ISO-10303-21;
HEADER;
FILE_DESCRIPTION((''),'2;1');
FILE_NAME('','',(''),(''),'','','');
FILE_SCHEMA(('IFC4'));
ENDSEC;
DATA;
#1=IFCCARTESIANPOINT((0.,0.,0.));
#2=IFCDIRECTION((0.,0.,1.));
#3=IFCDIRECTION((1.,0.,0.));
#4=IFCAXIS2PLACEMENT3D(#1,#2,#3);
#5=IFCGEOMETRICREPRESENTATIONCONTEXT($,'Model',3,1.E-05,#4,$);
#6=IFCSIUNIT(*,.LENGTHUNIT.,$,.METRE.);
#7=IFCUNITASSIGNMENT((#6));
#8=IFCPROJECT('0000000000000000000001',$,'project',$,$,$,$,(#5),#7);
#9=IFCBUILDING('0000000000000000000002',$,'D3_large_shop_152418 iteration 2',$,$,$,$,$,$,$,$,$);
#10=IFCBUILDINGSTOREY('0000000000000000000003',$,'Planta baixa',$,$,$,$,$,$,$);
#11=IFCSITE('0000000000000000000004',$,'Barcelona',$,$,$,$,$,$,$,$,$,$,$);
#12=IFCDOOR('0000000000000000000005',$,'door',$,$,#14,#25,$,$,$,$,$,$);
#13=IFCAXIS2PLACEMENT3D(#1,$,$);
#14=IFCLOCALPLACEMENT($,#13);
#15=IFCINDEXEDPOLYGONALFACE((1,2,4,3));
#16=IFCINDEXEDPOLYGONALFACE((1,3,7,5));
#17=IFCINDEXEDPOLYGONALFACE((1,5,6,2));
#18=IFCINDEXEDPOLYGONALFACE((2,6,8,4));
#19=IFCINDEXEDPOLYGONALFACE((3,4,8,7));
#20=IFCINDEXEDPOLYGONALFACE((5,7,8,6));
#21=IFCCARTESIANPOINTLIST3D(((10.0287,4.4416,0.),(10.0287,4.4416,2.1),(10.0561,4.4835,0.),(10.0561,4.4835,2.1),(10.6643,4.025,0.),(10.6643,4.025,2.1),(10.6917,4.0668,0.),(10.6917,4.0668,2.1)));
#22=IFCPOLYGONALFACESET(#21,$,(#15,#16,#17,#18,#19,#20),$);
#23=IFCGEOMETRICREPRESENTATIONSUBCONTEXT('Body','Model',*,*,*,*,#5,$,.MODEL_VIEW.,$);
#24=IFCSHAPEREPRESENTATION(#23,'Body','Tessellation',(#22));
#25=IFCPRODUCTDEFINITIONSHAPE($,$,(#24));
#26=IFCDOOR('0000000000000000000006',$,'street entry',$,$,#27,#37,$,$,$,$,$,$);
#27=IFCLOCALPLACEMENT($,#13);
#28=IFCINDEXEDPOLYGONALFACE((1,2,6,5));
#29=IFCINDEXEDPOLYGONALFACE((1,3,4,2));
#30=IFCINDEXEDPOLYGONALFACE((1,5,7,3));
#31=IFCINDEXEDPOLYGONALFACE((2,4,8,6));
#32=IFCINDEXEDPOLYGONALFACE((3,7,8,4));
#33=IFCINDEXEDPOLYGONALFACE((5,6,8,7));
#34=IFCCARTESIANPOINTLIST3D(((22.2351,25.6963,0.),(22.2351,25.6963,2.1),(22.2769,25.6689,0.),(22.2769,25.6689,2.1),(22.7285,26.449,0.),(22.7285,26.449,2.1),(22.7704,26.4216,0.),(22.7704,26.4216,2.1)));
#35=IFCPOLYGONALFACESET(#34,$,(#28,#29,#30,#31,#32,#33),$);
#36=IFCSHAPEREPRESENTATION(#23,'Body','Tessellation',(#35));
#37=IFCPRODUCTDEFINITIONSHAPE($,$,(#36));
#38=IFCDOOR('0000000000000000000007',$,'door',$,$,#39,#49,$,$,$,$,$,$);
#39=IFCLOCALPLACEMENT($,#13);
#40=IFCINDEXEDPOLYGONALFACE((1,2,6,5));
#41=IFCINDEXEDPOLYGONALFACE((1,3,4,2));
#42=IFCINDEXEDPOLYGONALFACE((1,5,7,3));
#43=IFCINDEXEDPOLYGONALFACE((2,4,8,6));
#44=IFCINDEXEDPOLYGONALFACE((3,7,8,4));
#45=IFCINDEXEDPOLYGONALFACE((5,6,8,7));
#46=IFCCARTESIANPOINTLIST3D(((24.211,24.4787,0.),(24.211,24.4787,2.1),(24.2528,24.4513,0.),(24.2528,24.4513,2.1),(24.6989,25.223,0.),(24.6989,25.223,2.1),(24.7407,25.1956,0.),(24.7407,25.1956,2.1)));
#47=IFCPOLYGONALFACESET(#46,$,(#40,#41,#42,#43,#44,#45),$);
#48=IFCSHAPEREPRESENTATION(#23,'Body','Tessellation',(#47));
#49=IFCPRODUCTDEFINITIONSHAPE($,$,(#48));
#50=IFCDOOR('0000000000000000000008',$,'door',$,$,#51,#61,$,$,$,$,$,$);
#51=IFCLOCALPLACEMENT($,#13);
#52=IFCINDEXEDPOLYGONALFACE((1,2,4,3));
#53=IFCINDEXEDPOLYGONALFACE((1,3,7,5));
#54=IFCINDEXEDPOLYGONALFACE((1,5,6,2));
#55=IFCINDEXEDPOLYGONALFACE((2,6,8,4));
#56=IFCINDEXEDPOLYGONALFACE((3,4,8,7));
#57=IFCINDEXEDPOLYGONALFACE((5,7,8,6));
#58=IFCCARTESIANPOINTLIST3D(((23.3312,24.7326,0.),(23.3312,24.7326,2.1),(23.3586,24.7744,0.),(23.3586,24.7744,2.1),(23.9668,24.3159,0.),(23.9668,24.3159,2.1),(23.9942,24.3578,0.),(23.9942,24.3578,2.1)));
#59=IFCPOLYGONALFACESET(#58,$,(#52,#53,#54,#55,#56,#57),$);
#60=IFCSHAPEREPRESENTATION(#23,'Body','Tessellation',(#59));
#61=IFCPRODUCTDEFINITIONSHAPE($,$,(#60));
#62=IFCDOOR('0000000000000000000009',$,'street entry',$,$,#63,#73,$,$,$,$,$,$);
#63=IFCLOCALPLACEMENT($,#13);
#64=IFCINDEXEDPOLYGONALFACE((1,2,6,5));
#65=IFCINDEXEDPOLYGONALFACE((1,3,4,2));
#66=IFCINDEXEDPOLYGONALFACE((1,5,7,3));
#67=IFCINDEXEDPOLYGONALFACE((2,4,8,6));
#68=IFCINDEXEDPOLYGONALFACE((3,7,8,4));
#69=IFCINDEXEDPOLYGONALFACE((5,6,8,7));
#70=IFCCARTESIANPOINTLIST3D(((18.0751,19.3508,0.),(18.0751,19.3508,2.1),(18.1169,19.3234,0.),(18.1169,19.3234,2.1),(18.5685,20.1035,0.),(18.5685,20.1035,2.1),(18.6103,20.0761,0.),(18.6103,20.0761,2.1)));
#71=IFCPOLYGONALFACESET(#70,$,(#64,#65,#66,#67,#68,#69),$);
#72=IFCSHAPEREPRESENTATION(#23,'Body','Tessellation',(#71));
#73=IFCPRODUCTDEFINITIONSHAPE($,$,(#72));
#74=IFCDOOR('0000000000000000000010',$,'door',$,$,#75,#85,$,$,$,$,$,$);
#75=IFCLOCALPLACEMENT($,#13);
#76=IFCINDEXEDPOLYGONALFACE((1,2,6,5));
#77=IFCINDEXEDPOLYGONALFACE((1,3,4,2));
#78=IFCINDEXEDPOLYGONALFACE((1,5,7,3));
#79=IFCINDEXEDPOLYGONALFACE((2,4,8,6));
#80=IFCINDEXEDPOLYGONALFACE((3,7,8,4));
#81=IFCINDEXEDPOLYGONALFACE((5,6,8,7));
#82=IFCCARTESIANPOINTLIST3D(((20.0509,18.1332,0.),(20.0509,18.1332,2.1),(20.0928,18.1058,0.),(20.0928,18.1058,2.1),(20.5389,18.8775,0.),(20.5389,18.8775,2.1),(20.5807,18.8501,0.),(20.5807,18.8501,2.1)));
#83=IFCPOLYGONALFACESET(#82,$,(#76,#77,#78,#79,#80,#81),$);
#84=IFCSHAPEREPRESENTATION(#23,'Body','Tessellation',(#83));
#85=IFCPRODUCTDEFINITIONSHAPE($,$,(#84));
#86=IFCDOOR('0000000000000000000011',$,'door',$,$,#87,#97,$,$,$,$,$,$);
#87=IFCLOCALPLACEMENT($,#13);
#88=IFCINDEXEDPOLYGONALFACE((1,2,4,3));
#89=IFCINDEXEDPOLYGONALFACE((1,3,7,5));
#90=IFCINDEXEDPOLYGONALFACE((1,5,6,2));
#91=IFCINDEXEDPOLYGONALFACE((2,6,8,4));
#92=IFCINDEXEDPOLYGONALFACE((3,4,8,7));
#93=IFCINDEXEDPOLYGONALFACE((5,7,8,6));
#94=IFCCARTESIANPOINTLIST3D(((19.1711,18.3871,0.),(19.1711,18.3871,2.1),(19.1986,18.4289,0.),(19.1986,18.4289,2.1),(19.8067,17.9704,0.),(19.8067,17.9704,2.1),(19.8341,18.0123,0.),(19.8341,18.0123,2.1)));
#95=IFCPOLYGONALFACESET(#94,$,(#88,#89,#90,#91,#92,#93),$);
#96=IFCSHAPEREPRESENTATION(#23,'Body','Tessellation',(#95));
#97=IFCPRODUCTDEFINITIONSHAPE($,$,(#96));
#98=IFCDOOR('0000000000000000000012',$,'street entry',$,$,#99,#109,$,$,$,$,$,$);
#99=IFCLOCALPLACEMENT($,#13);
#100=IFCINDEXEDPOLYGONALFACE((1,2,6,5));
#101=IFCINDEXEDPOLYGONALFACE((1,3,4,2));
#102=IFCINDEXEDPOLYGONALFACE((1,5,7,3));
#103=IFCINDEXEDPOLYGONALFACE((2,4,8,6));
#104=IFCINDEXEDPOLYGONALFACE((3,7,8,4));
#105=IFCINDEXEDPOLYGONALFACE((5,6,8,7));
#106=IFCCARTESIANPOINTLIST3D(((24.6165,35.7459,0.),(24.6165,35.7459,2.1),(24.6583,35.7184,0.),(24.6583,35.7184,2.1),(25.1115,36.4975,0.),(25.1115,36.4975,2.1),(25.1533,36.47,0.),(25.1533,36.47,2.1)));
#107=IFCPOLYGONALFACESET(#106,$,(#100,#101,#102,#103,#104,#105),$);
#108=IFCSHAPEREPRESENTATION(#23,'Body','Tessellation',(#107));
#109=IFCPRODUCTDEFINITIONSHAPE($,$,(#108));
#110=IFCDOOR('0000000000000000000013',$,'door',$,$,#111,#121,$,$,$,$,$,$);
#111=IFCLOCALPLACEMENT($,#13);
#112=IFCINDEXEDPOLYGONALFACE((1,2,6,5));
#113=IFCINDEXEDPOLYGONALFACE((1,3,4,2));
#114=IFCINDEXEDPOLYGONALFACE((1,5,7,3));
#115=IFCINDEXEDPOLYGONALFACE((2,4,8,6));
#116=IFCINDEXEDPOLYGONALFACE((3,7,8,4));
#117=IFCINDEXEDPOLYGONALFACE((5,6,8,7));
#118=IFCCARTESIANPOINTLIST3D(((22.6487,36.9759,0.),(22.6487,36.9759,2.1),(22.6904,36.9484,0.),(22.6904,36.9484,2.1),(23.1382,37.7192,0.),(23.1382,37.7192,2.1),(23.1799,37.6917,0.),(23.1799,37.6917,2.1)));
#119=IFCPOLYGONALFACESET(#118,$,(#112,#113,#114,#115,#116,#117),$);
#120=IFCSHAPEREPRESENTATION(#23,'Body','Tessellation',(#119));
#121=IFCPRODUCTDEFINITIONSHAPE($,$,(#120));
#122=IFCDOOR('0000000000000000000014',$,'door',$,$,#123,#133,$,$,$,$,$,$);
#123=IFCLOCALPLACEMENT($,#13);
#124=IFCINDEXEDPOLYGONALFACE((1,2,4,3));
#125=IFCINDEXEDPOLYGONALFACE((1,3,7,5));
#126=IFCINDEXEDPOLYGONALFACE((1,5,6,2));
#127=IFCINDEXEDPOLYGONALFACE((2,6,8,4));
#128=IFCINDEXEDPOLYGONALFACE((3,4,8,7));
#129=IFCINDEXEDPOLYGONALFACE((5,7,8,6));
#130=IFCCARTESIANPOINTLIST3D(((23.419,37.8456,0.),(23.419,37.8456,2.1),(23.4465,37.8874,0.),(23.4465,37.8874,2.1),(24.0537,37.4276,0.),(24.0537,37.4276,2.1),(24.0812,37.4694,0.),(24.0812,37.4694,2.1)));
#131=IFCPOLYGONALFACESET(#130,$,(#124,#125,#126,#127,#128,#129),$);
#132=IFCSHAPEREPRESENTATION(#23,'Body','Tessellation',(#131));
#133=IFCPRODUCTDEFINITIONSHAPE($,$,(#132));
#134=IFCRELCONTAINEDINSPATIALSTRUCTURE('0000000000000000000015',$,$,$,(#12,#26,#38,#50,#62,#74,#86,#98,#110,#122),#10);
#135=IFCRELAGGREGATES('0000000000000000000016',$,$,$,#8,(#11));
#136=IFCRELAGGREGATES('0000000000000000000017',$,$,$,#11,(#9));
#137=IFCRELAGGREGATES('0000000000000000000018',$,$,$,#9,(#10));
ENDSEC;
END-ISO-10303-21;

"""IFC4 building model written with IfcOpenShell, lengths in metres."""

from ifc_helpers import new_model, si_unit, origin, origin_with_axes, place, context, subcontext, project, spatial, polyline, outline, extrude, element, save


model = new_model("IFC4")

# Units and contexts
model_context = context("Model", 3, precision=1e-05, world=origin_with_axes())
body_context = subcontext(model_context, "Body", "Model", "MODEL_VIEW")
ifc_project = project(units=[si_unit("LENGTHUNIT", "METRE")], contexts=[model_context])

# Site, building, storey
site = spatial("IfcSite", under=ifc_project, Name="Barcelona")
building = spatial("IfcBuilding", under=site, Name="D3_large_shop_152418 iteration 2")
storey = spatial("IfcBuildingStorey", under=building, Name="Planta baixa")

# Doors
door_1_placement = place(None, origin_with_axes())
element("IfcDoor", 1, at=door_1_placement, inside=storey, Name="door", context=body_context, shape_type="SweptSolid", body=[
    extrude(outline(polyline([(10.6643, 4.025), (10.0287, 4.4416), (10.0561, 4.4835), (10.6917, 4.0668), (10.6643, 4.025)])), origin(), (0.0, 0.0, 1.0), 2.1),
])
door_2_placement = place(None, origin_with_axes())
element("IfcDoor", 2, at=door_2_placement, inside=storey, Name="street entry", context=body_context, shape_type="SweptSolid", body=[
    extrude(outline(polyline([(22.7704, 26.4216), (22.2769, 25.6689), (22.2351, 25.6963), (22.7285, 26.449), (22.7704, 26.4216)])), origin(), (0.0, 0.0, 1.0), 2.1),
])
door_3_placement = place(None, origin_with_axes())
element("IfcDoor", 3, at=door_3_placement, inside=storey, Name="door", context=body_context, shape_type="SweptSolid", body=[
    extrude(outline(polyline([(24.211, 24.4787), (24.6989, 25.223), (24.7407, 25.1956), (24.2528, 24.4513), (24.211, 24.4787)])), origin(), (0.0, 0.0, 1.0), 2.1),
])
door_4_placement = place(None, origin_with_axes())
element("IfcDoor", 4, at=door_4_placement, inside=storey, Name="door", context=body_context, shape_type="SweptSolid", body=[
    extrude(outline(polyline([(23.9668, 24.3159), (23.3312, 24.7326), (23.3586, 24.7744), (23.9942, 24.3578), (23.9668, 24.3159)])), origin(), (0.0, 0.0, 1.0), 2.1),
])
door_5_placement = place(None, origin_with_axes())
element("IfcDoor", 5, at=door_5_placement, inside=storey, Name="street entry", context=body_context, shape_type="SweptSolid", body=[
    extrude(outline(polyline([(18.6103, 20.0761), (18.1169, 19.3234), (18.0751, 19.3508), (18.5685, 20.1035), (18.6103, 20.0761)])), origin(), (0.0, 0.0, 1.0), 2.1),
])
door_6_placement = place(None, origin_with_axes())
element("IfcDoor", 6, at=door_6_placement, inside=storey, Name="door", context=body_context, shape_type="SweptSolid", body=[
    extrude(outline(polyline([(20.0509, 18.1332), (20.5389, 18.8775), (20.5807, 18.8501), (20.0928, 18.1058), (20.0509, 18.1332)])), origin(), (0.0, 0.0, 1.0), 2.1),
])
door_7_placement = place(None, origin_with_axes())
element("IfcDoor", 7, at=door_7_placement, inside=storey, Name="door", context=body_context, shape_type="SweptSolid", body=[
    extrude(outline(polyline([(19.8067, 17.9704), (19.1711, 18.3871), (19.1986, 18.4289), (19.8341, 18.0123), (19.8067, 17.9704)])), origin(), (0.0, 0.0, 1.0), 2.1),
])
door_8_placement = place(None, origin_with_axes())
element("IfcDoor", 8, at=door_8_placement, inside=storey, Name="street entry", context=body_context, shape_type="SweptSolid", body=[
    extrude(outline(polyline([(24.6165, 35.7459), (25.1115, 36.4975), (25.1533, 36.47), (24.6583, 35.7184), (24.6165, 35.7459)])), origin(), (0.0, 0.0, 1.0), 2.1),
])
door_9_placement = place(None, origin_with_axes())
element("IfcDoor", 9, at=door_9_placement, inside=storey, Name="door", context=body_context, shape_type="SweptSolid", body=[
    extrude(outline(polyline([(22.6487, 36.9759), (23.1382, 37.7192), (23.1799, 37.6917), (22.6904, 36.9484), (22.6487, 36.9759)])), origin(), (0.0, 0.0, 1.0), 2.1),
])
door_10_placement = place(None, origin_with_axes())
element("IfcDoor", 10, at=door_10_placement, inside=storey, Name="door", context=body_context, shape_type="SweptSolid", body=[
    extrude(outline(polyline([(23.4465, 37.8874), (24.0812, 37.4694), (24.0537, 37.4276), (23.419, 37.8456), (23.4465, 37.8874)])), origin(), (0.0, 0.0, 1.0), 2.1),
])

save(model, "model.ifc")
